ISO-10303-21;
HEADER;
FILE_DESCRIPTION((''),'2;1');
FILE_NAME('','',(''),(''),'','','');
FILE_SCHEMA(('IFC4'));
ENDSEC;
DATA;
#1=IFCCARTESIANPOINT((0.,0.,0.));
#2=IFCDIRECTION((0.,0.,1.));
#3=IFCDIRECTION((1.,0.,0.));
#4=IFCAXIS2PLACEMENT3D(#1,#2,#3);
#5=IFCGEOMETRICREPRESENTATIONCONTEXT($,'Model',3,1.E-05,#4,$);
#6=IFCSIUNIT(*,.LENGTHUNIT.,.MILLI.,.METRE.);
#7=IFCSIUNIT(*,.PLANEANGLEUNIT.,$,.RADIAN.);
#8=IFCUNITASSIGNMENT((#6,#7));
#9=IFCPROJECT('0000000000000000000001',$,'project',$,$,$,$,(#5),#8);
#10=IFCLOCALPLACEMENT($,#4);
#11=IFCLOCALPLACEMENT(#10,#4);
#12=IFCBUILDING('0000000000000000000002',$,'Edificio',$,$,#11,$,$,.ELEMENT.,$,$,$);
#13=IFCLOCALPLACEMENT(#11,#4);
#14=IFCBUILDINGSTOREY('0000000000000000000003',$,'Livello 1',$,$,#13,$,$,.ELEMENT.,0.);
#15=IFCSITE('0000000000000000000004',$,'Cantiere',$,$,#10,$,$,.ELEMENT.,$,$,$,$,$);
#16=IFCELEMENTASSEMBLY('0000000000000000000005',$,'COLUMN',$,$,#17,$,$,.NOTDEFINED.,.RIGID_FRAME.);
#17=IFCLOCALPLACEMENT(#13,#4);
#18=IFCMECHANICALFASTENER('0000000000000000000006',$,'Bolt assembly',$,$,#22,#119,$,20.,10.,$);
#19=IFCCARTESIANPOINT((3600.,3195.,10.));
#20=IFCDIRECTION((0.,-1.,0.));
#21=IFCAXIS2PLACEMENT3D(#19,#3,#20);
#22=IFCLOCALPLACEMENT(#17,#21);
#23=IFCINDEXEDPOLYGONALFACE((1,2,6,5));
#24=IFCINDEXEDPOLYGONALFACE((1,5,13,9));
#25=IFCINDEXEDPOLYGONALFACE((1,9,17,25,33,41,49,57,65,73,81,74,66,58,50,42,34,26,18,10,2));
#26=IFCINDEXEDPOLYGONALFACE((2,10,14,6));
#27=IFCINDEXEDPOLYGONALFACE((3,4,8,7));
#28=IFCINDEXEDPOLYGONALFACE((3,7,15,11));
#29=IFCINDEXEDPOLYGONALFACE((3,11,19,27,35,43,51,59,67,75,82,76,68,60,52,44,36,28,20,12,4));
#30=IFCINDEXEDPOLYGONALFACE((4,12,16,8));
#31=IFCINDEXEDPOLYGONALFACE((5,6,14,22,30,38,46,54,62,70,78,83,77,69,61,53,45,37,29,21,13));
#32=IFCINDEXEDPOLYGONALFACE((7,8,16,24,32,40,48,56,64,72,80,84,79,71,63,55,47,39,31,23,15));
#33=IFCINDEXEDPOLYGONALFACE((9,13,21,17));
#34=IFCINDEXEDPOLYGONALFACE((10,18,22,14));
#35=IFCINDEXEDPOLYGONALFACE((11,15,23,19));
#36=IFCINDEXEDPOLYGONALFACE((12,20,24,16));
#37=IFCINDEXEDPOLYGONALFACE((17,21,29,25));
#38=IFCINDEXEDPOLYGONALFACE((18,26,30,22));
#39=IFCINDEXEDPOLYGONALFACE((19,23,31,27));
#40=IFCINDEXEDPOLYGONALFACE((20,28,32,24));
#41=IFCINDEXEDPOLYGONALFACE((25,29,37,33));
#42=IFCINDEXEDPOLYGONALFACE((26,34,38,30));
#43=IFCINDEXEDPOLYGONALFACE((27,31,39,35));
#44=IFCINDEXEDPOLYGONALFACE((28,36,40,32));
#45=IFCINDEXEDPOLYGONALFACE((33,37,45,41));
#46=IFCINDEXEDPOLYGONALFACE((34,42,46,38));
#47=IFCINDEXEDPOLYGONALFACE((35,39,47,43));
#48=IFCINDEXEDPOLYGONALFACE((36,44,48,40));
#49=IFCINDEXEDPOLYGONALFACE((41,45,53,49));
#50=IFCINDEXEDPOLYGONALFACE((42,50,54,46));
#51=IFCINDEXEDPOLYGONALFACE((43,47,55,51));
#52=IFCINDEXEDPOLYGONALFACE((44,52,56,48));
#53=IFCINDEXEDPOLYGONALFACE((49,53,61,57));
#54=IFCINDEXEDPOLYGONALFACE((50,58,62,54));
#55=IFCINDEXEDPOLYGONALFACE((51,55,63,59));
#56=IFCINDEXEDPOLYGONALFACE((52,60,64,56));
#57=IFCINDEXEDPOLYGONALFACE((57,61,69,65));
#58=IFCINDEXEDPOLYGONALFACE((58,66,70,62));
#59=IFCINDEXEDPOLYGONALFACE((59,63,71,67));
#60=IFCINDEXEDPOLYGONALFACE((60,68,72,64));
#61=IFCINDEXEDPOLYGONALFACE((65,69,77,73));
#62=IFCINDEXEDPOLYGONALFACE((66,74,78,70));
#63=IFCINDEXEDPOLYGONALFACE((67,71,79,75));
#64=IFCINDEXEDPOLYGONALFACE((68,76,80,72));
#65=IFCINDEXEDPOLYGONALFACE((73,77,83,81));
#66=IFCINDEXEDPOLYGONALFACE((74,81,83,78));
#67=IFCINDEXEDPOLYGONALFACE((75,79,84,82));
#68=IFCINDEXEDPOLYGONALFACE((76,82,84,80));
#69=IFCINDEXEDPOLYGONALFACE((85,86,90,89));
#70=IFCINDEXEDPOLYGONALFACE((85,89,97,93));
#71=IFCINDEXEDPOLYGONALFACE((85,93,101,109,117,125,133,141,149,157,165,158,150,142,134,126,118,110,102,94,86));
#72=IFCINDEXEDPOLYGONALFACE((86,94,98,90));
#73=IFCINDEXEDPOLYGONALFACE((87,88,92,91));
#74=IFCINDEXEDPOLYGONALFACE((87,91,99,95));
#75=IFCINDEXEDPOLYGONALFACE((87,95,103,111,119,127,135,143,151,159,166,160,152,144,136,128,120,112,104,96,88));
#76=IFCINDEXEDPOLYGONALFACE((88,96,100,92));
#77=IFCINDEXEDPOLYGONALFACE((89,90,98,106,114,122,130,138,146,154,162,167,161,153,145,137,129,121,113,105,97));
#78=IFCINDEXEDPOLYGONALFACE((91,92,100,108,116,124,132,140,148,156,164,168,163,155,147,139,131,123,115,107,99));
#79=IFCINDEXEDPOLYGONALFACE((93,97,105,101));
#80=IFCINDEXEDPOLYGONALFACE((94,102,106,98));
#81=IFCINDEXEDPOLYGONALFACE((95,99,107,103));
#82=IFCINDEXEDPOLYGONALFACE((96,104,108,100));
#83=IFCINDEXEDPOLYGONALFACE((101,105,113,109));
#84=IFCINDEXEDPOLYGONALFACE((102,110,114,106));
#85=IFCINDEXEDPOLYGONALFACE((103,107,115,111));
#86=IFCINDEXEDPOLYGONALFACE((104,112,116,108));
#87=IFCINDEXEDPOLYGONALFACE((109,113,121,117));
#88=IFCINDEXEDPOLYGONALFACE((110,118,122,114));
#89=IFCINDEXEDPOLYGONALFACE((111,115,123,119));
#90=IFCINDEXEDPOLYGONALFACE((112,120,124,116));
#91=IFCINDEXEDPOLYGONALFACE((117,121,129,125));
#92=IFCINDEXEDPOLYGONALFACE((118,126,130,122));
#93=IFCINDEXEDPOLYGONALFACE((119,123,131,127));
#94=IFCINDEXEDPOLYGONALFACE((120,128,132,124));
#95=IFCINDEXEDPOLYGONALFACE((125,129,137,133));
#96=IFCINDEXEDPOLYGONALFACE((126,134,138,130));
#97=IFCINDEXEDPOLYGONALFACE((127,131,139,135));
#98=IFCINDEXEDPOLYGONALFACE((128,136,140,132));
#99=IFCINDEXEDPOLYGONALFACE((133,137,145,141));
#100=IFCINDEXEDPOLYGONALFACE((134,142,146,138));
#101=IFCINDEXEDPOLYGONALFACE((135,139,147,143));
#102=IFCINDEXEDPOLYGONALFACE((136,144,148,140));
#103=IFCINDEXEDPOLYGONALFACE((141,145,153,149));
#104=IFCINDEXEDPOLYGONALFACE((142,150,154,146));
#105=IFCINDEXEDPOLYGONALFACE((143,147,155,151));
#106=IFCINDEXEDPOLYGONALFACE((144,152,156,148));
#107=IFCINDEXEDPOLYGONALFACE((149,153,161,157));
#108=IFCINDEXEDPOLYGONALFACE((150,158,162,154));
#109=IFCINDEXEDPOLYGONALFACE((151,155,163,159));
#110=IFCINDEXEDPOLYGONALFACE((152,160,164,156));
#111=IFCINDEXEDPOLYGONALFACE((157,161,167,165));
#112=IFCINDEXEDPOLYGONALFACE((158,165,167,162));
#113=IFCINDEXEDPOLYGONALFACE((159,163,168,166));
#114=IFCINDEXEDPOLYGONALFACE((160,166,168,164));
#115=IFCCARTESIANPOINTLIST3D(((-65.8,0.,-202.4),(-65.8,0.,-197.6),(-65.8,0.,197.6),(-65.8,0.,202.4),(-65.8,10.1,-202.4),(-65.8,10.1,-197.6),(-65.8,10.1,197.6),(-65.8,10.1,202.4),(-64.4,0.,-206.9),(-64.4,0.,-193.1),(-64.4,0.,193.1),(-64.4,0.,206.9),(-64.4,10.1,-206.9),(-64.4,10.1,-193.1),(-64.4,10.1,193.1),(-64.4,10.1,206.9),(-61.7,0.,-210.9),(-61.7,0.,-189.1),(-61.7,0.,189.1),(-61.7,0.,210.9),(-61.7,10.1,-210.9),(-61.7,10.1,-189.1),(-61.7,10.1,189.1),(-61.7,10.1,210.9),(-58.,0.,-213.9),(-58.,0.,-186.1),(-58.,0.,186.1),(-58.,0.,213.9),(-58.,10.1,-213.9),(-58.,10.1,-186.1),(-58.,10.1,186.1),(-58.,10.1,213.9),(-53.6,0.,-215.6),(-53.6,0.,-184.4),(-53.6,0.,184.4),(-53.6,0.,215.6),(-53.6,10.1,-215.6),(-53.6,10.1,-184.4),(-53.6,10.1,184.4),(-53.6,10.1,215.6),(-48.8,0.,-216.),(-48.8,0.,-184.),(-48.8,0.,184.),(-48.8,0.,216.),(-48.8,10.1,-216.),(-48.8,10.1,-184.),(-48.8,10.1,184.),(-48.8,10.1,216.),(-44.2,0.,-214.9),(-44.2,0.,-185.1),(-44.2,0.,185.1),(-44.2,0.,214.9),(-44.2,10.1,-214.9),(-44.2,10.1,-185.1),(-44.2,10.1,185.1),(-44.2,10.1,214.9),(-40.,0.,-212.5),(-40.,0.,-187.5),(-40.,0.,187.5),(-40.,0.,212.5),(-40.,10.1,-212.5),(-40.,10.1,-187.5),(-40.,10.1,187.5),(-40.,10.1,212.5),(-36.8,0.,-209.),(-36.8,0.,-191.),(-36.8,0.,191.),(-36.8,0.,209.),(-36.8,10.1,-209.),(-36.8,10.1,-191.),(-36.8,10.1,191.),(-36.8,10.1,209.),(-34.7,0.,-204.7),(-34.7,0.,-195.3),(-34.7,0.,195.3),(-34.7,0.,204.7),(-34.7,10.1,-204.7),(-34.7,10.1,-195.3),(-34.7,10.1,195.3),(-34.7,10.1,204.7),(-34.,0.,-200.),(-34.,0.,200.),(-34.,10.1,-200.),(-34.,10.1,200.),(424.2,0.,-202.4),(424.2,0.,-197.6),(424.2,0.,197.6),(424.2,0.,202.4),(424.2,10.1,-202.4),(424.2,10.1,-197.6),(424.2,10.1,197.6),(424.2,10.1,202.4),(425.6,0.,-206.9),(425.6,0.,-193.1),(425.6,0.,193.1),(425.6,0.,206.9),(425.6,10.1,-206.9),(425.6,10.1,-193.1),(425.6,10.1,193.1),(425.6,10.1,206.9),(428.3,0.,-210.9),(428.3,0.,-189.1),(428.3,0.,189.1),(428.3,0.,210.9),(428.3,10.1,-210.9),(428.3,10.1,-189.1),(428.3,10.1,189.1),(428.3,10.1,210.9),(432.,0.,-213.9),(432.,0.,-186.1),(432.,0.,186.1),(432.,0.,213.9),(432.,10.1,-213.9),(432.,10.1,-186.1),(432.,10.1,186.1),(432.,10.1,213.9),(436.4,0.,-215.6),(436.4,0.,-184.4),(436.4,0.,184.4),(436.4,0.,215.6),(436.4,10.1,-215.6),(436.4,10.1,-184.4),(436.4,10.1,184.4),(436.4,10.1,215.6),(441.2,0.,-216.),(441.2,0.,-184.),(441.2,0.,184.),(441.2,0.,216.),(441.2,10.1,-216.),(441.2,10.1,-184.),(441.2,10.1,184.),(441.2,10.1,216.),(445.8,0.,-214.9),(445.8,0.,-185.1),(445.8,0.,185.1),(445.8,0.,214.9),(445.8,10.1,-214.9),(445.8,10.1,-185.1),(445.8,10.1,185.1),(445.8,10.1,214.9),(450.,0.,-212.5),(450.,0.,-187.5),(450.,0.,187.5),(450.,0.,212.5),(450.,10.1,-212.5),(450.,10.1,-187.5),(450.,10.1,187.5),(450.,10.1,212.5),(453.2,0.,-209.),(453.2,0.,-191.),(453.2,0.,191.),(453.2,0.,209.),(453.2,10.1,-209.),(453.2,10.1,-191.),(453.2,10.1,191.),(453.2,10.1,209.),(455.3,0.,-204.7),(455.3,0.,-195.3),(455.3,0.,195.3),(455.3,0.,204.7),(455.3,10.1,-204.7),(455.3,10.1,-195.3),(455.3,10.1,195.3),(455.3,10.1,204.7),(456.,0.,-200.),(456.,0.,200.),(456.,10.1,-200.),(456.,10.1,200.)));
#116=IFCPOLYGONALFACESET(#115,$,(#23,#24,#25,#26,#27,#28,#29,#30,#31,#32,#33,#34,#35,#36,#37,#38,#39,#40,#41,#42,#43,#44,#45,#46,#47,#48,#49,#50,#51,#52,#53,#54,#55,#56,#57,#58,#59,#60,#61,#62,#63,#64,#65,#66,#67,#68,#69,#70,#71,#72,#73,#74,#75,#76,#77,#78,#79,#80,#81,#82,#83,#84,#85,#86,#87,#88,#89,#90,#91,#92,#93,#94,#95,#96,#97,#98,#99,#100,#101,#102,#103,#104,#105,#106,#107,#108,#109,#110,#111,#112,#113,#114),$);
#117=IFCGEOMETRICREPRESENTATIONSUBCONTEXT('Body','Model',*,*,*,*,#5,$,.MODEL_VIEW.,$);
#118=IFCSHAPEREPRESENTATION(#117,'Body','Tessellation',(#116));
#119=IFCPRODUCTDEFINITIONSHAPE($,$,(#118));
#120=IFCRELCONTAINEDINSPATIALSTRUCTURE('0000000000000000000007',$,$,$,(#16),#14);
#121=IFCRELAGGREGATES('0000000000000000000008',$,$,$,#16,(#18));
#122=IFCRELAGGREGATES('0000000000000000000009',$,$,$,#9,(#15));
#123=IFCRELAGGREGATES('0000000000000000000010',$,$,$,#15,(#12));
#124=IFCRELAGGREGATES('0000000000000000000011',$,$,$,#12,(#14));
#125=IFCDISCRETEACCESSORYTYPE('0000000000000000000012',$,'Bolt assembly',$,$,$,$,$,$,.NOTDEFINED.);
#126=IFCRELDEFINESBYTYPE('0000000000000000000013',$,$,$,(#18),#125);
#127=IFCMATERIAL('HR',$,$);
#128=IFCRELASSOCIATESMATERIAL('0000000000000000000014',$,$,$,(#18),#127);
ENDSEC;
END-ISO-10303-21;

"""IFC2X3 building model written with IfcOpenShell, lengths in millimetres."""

from ifc_helpers import new_model, si_unit, frame, origin_with_axes, origin_2d_with_axis, place, context, subcontext, project, spatial, circle, extrude, source, transform, mapped, material, type_object, element, aggregate, save


model = new_model("IFC2X3")

# Units and contexts
model_context = context("Model", 3, precision=1e-05, world=origin_with_axes())
body_context = subcontext(model_context, "Body", "Model", "MODEL_VIEW")
ifc_project = project(units=[si_unit("LENGTHUNIT", "METRE", prefix="MILLI"), si_unit("PLANEANGLEUNIT", "RADIAN")], contexts=[model_context])

# Site, building, storey
site_placement = place(None, origin_with_axes())
site = spatial("IfcSite", under=ifc_project, at=site_placement, Name="Cantiere", CompositionType="ELEMENT")
building_placement = place(site_placement, origin_with_axes())
building = spatial("IfcBuilding", under=site, at=building_placement, Name="Edificio", CompositionType="ELEMENT")
storey_placement = place(building_placement, origin_with_axes())
storey = spatial("IfcBuildingStorey", under=building, at=storey_placement, Name="Livello 1", CompositionType="ELEMENT", Elevation=0.0)

# Element assembly
assembly_1_placement = place(storey_placement, origin_with_axes())
assembly_1 = element("IfcElementAssembly", 1, at=assembly_1_placement, inside=storey, Name="COLUMN", AssemblyPlace="NOTDEFINED", PredefinedType="RIGID_FRAME")

# Mechanical fastener
ifc_material_1 = material(Name="HR")
discrete_accessory_type_1 = type_object("IfcDiscreteAccessoryType", Name="Bolt assembly")
shared_shape_1 = source(origin_with_axes(), body_context, "Body", "SweptSolid", [
    extrude(circle(Radius=16.0, at=origin_2d_with_axis()), frame((0.0, 0.0, 0.0), z_axis=(0.0, 1.0, 0.0), x_axis=(1.0, 0.0, 0.0)), (0.0, 0.0, 1.0), 10.1),
])
mechanical_fastener_1_placement = place(assembly_1_placement, frame((3600.0, 3195.0, 10.0), z_axis=(1.0, 0.0, 0.0), x_axis=(0.0, -1.0, 0.0)))
mechanical_fastener_1 = element("IfcMechanicalFastener", 2, at=mechanical_fastener_1_placement, type_object=discrete_accessory_type_1, material=ifc_material_1, Name="Bolt assembly", NominalDiameter=20.0, NominalLength=10.0, context=body_context, shape_type="MappedRepresentation", body=[
    mapped(shared_shape_1, transform((-50.0, 0.0, -200.0))),
    mapped(shared_shape_1, transform((-50.0, 0.0, 200.0))),
    mapped(shared_shape_1, transform((440.0, 0.0, -200.0))),
    mapped(shared_shape_1, transform((440.0, 0.0, 200.0))),
])
aggregate(assembly_1, [mechanical_fastener_1])

save(model, "model.ifc")
